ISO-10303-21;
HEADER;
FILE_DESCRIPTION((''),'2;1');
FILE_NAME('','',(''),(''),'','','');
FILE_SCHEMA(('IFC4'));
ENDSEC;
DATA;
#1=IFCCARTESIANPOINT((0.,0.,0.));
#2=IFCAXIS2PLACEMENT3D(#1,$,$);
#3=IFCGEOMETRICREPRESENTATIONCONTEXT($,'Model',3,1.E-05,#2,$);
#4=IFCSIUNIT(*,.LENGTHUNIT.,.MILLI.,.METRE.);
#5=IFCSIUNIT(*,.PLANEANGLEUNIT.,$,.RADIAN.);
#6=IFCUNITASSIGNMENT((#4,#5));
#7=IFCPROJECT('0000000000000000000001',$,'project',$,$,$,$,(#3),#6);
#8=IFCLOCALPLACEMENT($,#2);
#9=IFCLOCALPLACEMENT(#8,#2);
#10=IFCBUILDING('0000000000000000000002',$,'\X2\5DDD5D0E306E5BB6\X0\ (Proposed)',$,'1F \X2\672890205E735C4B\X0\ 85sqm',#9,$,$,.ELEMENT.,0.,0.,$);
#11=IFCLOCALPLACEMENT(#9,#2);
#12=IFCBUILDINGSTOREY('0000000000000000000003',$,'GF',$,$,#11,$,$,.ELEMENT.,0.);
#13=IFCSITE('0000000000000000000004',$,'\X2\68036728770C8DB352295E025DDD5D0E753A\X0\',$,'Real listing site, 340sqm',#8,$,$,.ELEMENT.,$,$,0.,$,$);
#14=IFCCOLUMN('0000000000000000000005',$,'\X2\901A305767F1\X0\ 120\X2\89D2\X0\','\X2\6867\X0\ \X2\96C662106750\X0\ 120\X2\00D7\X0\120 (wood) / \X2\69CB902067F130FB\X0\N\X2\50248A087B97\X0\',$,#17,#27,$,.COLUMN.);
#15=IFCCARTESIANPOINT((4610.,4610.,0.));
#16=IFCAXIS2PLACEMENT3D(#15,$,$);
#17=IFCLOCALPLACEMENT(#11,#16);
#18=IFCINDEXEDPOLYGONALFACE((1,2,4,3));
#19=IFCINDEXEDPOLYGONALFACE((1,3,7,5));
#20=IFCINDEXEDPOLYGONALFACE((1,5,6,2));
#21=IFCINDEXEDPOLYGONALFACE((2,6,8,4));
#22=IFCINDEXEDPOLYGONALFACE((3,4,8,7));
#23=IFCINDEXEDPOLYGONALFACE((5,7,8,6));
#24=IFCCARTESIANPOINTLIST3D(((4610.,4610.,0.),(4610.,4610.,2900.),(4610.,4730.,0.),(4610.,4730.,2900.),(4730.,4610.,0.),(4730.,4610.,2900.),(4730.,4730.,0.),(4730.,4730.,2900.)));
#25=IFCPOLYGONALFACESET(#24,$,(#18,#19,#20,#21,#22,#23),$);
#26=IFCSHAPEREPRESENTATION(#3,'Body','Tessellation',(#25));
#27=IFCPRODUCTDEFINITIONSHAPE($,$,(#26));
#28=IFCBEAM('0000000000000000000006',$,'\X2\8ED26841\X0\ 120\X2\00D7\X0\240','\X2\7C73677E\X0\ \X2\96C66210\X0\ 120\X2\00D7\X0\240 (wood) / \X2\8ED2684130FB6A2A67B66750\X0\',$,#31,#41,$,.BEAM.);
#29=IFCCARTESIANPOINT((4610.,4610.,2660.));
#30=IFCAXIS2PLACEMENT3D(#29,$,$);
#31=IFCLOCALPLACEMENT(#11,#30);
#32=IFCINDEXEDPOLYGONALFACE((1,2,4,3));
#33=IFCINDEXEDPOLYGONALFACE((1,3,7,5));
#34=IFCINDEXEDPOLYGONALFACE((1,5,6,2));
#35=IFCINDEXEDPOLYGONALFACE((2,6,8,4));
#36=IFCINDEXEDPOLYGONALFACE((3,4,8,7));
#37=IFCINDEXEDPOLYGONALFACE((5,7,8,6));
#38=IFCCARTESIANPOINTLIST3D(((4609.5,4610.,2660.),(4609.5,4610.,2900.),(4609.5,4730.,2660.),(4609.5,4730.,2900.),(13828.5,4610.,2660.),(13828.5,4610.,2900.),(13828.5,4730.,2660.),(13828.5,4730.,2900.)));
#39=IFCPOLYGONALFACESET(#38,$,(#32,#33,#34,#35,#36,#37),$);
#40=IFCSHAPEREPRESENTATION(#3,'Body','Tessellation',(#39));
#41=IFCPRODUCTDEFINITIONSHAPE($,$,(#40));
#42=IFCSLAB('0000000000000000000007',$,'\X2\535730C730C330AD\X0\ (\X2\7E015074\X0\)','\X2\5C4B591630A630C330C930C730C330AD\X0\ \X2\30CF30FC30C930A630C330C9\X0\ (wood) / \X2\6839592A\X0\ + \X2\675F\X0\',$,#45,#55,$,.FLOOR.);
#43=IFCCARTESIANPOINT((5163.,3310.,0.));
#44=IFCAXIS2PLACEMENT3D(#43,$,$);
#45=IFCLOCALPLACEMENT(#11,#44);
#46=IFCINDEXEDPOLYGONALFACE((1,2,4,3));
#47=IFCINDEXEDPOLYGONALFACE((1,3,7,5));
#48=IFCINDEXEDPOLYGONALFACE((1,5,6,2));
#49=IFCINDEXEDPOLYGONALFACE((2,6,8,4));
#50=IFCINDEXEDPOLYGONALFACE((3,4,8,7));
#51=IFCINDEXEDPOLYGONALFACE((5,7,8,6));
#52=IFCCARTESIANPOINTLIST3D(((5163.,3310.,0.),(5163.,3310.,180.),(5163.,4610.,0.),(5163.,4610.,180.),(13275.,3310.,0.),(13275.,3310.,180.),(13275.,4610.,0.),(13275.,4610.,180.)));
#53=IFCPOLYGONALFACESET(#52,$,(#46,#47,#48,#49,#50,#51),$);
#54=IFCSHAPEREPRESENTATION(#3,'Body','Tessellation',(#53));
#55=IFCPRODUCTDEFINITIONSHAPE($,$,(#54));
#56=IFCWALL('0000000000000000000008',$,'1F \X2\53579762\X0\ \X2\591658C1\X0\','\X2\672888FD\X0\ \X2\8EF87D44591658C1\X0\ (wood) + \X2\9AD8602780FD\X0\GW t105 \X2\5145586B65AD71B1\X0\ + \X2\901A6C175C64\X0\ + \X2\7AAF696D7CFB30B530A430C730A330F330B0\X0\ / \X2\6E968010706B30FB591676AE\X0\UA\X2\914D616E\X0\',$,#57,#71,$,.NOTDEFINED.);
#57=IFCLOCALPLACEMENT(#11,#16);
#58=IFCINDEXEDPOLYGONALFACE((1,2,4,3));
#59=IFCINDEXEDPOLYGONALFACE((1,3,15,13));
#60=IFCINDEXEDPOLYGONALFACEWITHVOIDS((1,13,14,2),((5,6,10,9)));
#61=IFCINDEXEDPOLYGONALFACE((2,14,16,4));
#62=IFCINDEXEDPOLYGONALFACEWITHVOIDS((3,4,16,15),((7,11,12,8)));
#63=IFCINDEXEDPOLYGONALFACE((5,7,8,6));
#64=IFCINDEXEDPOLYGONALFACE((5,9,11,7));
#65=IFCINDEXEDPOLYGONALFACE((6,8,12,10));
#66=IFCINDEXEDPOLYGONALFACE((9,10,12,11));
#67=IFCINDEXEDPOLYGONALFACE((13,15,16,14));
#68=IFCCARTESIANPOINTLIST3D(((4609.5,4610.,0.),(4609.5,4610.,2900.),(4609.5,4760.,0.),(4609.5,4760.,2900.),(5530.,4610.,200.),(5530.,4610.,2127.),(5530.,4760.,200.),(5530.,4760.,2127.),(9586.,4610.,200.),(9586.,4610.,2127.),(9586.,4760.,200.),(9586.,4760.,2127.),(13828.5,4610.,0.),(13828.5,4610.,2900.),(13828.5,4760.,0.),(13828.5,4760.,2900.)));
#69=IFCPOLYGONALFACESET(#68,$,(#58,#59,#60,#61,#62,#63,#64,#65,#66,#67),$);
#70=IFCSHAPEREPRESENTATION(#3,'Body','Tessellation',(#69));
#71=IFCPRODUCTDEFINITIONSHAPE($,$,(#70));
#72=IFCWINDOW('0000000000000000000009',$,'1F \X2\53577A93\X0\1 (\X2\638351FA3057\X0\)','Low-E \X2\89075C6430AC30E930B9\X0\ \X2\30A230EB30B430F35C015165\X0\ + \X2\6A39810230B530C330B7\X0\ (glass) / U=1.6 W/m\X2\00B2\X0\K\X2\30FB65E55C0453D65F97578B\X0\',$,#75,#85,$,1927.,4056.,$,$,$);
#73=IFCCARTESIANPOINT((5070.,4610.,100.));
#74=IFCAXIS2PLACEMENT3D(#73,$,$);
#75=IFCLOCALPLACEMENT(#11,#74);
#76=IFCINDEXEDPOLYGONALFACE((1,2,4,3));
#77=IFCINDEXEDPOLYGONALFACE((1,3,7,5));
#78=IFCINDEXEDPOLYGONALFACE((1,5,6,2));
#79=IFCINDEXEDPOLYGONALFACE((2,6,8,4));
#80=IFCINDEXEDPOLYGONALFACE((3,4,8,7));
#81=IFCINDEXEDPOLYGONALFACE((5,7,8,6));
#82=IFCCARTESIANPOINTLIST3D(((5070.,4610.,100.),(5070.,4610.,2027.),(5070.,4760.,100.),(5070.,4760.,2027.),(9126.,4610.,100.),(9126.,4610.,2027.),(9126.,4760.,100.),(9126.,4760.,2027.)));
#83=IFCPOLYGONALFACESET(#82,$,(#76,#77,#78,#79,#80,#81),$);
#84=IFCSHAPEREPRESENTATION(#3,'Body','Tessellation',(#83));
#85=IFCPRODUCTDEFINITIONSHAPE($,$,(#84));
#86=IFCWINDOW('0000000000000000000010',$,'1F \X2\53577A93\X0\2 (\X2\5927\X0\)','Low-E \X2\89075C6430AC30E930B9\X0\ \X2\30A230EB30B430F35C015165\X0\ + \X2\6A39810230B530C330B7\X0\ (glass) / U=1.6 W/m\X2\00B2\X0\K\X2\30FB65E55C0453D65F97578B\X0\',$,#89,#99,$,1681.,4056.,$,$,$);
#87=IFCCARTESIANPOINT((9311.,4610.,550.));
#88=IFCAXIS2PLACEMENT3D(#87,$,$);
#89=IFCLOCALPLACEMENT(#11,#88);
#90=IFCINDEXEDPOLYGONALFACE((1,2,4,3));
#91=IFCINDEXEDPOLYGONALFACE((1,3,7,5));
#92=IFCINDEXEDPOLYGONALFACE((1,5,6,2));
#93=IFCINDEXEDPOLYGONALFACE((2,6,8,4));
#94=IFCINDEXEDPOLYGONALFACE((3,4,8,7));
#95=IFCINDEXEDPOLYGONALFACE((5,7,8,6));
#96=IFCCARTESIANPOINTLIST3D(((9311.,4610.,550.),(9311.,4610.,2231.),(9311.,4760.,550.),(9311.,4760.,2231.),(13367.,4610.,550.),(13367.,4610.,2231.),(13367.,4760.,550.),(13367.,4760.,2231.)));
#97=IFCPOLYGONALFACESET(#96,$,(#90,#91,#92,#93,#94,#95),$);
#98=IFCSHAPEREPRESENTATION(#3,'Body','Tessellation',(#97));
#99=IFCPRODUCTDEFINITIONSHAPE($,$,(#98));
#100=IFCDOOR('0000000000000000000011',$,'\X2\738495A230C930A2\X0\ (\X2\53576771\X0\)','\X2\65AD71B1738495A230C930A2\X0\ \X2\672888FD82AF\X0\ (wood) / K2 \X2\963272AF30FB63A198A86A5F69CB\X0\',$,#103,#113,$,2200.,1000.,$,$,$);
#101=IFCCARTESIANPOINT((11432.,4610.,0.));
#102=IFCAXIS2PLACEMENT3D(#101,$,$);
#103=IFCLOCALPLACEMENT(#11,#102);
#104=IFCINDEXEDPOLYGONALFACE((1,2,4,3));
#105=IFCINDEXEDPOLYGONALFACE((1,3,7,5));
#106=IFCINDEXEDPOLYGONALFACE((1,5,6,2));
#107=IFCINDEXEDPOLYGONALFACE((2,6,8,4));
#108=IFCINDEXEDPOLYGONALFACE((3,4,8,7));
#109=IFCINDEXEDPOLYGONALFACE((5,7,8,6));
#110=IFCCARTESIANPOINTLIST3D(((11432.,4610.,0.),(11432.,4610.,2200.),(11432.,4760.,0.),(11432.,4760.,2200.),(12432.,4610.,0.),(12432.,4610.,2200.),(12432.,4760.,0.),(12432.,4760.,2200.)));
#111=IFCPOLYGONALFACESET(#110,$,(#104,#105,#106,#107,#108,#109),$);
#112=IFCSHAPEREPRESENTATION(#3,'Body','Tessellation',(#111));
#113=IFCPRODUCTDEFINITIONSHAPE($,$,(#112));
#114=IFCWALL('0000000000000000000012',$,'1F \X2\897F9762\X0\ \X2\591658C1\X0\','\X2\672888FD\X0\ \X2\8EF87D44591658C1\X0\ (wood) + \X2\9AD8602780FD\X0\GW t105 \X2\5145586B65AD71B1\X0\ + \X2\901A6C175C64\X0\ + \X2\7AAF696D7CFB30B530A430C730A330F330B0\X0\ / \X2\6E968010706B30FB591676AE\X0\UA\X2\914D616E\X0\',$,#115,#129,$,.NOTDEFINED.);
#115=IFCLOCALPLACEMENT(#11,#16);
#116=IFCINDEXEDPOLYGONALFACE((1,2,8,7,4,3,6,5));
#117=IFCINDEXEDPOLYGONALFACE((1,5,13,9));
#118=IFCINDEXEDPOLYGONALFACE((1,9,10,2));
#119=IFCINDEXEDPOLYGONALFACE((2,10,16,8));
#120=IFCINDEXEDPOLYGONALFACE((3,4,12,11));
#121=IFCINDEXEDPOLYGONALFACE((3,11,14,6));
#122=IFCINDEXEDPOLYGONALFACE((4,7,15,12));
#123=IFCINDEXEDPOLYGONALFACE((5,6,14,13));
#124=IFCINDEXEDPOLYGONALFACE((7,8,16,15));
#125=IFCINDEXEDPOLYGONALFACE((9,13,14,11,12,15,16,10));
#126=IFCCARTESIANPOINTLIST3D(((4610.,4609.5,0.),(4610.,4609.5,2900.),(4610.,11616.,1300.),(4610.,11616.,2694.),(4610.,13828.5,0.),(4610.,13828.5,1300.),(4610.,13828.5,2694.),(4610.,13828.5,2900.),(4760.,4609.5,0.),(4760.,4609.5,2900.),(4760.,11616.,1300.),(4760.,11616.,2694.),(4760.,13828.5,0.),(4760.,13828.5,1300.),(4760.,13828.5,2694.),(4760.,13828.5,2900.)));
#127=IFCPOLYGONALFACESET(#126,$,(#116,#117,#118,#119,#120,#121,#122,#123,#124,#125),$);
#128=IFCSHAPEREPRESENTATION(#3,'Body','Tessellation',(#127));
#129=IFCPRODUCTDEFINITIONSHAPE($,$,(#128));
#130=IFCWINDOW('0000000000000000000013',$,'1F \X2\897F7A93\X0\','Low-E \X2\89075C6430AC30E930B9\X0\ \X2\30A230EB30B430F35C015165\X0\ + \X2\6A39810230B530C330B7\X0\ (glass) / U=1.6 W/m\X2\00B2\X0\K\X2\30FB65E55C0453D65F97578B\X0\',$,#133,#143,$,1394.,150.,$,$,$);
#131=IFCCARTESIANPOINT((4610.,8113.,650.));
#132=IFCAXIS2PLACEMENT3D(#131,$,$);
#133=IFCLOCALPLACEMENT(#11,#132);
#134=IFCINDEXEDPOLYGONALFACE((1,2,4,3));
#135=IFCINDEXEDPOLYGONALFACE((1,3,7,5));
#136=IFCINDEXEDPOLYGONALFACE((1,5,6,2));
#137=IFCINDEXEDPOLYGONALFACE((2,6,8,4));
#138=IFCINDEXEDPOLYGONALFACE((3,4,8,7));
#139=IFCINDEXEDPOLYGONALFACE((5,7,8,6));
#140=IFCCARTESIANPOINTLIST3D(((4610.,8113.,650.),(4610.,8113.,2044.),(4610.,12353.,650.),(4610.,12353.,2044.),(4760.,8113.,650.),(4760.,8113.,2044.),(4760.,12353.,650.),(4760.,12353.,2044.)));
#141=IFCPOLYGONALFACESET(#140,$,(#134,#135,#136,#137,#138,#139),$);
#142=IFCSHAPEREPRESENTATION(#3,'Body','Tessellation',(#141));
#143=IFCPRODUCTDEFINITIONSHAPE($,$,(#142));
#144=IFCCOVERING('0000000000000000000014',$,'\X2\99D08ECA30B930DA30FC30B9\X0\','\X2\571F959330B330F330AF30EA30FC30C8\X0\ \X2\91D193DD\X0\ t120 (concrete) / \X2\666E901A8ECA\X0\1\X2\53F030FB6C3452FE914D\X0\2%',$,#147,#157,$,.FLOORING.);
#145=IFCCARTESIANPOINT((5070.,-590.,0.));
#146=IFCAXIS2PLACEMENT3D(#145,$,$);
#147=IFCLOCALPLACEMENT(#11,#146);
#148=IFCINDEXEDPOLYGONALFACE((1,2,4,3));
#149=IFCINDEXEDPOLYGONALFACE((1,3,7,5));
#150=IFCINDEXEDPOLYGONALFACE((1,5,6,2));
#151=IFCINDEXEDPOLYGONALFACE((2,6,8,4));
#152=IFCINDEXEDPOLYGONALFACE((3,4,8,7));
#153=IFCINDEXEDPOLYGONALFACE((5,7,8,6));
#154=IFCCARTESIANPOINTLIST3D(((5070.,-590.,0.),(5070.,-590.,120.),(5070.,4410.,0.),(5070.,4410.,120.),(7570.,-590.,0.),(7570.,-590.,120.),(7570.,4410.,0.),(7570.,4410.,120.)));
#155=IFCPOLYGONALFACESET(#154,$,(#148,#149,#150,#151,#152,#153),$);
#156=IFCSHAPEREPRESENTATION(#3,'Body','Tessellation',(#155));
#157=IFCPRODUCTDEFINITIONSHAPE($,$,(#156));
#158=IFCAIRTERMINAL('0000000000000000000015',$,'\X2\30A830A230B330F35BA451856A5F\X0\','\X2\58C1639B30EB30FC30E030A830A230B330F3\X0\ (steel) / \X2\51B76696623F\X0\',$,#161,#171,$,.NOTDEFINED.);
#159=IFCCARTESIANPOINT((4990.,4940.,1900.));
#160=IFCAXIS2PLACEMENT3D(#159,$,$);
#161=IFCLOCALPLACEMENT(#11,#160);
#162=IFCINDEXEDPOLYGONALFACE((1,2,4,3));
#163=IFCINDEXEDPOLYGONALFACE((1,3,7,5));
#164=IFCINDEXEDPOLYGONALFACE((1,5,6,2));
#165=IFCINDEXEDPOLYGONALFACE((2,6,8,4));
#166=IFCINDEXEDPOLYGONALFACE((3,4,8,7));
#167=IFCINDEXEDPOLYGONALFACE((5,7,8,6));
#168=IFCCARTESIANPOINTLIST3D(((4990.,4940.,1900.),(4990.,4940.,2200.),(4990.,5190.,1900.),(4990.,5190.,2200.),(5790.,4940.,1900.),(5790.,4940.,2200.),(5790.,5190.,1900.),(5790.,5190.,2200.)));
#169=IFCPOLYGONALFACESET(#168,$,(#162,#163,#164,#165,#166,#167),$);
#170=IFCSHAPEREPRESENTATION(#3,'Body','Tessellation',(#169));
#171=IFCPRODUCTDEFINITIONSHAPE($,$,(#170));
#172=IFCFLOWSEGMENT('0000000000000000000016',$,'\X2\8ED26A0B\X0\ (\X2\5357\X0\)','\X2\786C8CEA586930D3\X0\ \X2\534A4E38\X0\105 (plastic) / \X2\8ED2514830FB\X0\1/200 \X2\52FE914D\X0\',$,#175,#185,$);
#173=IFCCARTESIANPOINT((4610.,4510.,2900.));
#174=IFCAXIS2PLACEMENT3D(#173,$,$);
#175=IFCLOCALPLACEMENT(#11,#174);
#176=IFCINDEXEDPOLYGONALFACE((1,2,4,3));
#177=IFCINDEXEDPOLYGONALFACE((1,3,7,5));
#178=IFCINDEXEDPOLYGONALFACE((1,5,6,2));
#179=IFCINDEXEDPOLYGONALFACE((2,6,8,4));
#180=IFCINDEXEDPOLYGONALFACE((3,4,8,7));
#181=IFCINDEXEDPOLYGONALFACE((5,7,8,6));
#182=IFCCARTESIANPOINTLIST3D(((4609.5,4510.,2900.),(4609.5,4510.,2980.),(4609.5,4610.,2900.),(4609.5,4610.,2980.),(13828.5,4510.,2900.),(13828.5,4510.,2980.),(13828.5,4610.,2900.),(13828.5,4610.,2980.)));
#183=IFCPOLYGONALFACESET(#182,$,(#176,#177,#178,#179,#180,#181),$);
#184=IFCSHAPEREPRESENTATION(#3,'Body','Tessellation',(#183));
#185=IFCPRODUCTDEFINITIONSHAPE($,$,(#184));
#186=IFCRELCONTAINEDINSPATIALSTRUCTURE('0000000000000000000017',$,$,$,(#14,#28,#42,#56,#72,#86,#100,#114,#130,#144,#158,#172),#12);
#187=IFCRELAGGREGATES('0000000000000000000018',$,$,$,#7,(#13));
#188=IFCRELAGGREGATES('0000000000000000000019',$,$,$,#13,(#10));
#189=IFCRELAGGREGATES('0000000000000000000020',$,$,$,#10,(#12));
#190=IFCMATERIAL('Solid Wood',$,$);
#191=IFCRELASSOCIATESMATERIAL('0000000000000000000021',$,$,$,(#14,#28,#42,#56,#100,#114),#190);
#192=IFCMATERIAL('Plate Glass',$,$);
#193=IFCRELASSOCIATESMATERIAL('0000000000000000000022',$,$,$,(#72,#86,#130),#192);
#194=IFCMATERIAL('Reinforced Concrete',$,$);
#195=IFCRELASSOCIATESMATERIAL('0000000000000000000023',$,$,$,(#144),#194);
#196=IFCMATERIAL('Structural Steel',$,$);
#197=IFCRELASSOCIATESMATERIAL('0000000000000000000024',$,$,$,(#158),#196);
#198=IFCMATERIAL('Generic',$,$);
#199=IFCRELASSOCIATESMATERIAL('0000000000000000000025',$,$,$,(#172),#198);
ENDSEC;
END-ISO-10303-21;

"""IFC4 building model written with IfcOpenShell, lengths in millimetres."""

from ifc_helpers import new_model, si_unit, frame, frame_2d, origin, place, context, project, spatial, rectangle, extrude, material, element, fill, save


model = new_model("IFC4")

# Units and contexts
model_context = context("Model", 3, precision=1e-05, world=origin())
ifc_project = project(units=[si_unit("LENGTHUNIT", "METRE", prefix="MILLI"), si_unit("PLANEANGLEUNIT", "RADIAN")], contexts=[model_context])

# Site, building, storey
site_placement = place(None, origin())
site = spatial("IfcSite", under=ifc_project, at=site_placement, Name="栃木県足利市川崎町", ObjectType="Real listing site, 340sqm", CompositionType="ELEMENT", RefElevation=0.0)
building_placement = place(site_placement, origin())
building = spatial("IfcBuilding", under=site, at=building_placement, Name="川崎の家 (Proposed)", ObjectType="1F 木造平屋 85sqm", CompositionType="ELEMENT", ElevationOfRefHeight=0.0, ElevationOfTerrain=0.0)
storey_placement = place(building_placement, origin())
storey = spatial("IfcBuildingStorey", under=building, at=storey_placement, Name="GF", CompositionType="ELEMENT", Elevation=0.0)

# Column
ifc_material_1 = material(Name="Solid Wood")
column_1_placement = place(storey_placement, frame((4610.0, 4610.0, 0.0)))
element("IfcColumn", 1, at=column_1_placement, inside=storey, material=ifc_material_1, Name="通し柱 120角", Description="桧 集成材 120×120 (wood) / 構造柱・N値計算", PredefinedType="COLUMN", context=model_context, shape_type="SweptSolid", body=[
    extrude(rectangle(XDim=120.0, YDim=120.0, at=frame_2d((60.0, 60.0))), frame((4610.0, 4610.0, 0.0)), (0.0, 0.0, 1.0), 2900.0),
])

# Beam
beam_1_placement = place(storey_placement, frame((4610.0, 4610.0, 2660.0)))
element("IfcBeam", 2, at=beam_1_placement, inside=storey, material=ifc_material_1, Name="軒桁 120×240", Description="米松 集成 120×240 (wood) / 軒桁・横架材", PredefinedType="BEAM", context=model_context, shape_type="SweptSolid", body=[
    extrude(rectangle(XDim=9219.0, YDim=120.0, at=frame_2d((4609.0, 60.0))), frame((4610.0, 4610.0, 2660.0)), (0.0, 0.0, 1.0), 240.0),
])

# Slab
ifc_material_2 = material(Name="Reinforced Concrete")
slab_1_placement = place(storey_placement, frame((5163.0, 3310.0, 0.0)))
element("IfcSlab", 3, at=slab_1_placement, inside=storey, material=ifc_material_1, Name="南デッキ (縁側)", Description="屋外ウッドデッキ ハードウッド (wood) / 根太 + 束", PredefinedType="FLOOR", context=model_context, shape_type="SweptSolid", body=[
    extrude(rectangle(XDim=8112.0, YDim=1300.0, at=frame_2d((4056.0, 650.0))), frame((5163.0, 3310.0, 0.0)), (0.0, 0.0, 1.0), 180.0),
])

# Wall, openings, windows, door
wall_1_placement = place(storey_placement, frame((4610.0, 4610.0, 0.0)))
wall_1 = element("IfcWall", 4, at=wall_1_placement, inside=storey, material=ifc_material_1, Name="1F 南面 外壁", Description="木製 軸組外壁 (wood) + 高性能GW t105 充填断熱 + 通気層 + 窯業系サイディング / 準耐火・外皮UA配慮", PredefinedType="NOTDEFINED", context=model_context, shape_type="SweptSolid", body=[
    extrude(rectangle(XDim=9219.0, YDim=150.0, at=frame_2d((4609.0, 75.0))), frame((4610.0, 4610.0, 0.0)), (0.0, 0.0, 1.0), 2900.0),
])
opening_1_placement = place(storey_placement, frame((5070.0, 4610.0, 100.0)))
opening_1 = element("IfcOpeningElement", 5, at=opening_1_placement, cuts=wall_1, PredefinedType="NOTDEFINED", context=model_context, shape_type="SweptSolid", body=[
    extrude(rectangle(XDim=4056.0, YDim=150.0, at=frame_2d((2028.0, 75.0))), frame((5070.0, 4610.0, 100.0)), (0.0, 0.0, 1.0), 1927.0),
])
opening_2_placement = place(storey_placement, frame((9311.0, 4610.0, 550.0)))
opening_2 = element("IfcOpeningElement", 6, at=opening_2_placement, cuts=wall_1, PredefinedType="NOTDEFINED", context=model_context, shape_type="SweptSolid", body=[
    extrude(rectangle(XDim=4056.0, YDim=150.0, at=frame_2d((2028.0, 75.0))), frame((9311.0, 4610.0, 550.0)), (0.0, 0.0, 1.0), 1681.0),
])
opening_3_placement = place(storey_placement, frame((11432.0, 4610.0, 0.0)))
opening_3 = element("IfcOpeningElement", 7, at=opening_3_placement, cuts=wall_1, PredefinedType="NOTDEFINED", context=model_context, shape_type="SweptSolid", body=[
    extrude(rectangle(XDim=1000.0, YDim=150.0, at=frame_2d((500.0, 75.0))), frame((11432.0, 4610.0, 0.0)), (0.0, 0.0, 1.0), 2200.0),
])
ifc_material_3 = material(Name="Plate Glass")
window_1_placement = place(storey_placement, frame((5070.0, 4610.0, 100.0)))
window_1 = element("IfcWindow", 8, at=window_1_placement, inside=storey, material=ifc_material_3, Name="1F 南窓1 (掃出し)", Description="Low-E 複層ガラス アルゴン封入 + 樹脂サッシ (glass) / U=1.6 W/m²K・日射取得型", OverallHeight=1927.0, OverallWidth=4056.0, context=model_context, shape_type="SweptSolid", body=[
    extrude(rectangle(XDim=4056.0, YDim=150.0, at=frame_2d((2028.0, 75.0))), frame((5070.0, 4610.0, 100.0)), (0.0, 0.0, 1.0), 1927.0),
])
fill(opening_1, window_1)
window_2_placement = place(storey_placement, frame((9311.0, 4610.0, 550.0)))
window_2 = element("IfcWindow", 9, at=window_2_placement, inside=storey, material=ifc_material_3, Name="1F 南窓2 (大)", Description="Low-E 複層ガラス アルゴン封入 + 樹脂サッシ (glass) / U=1.6 W/m²K・日射取得型", OverallHeight=1681.0, OverallWidth=4056.0, context=model_context, shape_type="SweptSolid", body=[
    extrude(rectangle(XDim=4056.0, YDim=150.0, at=frame_2d((2028.0, 75.0))), frame((9311.0, 4610.0, 550.0)), (0.0, 0.0, 1.0), 1681.0),
])
fill(opening_2, window_2)
door_placement = place(storey_placement, frame((11432.0, 4610.0, 0.0)))
door = element("IfcDoor", 10, at=door_placement, inside=storey, material=ifc_material_1, Name="玄関ドア (南東)", Description="断熱玄関ドア 木製芯 (wood) / K2 防犯・採風機構", OverallHeight=2200.0, OverallWidth=1000.0, context=model_context, shape_type="SweptSolid", body=[
    extrude(rectangle(XDim=1000.0, YDim=150.0, at=frame_2d((500.0, 75.0))), frame((11432.0, 4610.0, 0.0)), (0.0, 0.0, 1.0), 2200.0),
])
fill(opening_3, door)

# Wall, opening, window
wall_2_placement = place(storey_placement, frame((4610.0, 4610.0, 0.0)))
wall_2 = element("IfcWall", 11, at=wall_2_placement, inside=storey, material=ifc_material_1, Name="1F 西面 外壁", Description="木製 軸組外壁 (wood) + 高性能GW t105 充填断熱 + 通気層 + 窯業系サイディング / 準耐火・外皮UA配慮", PredefinedType="NOTDEFINED", context=model_context, shape_type="SweptSolid", body=[
    extrude(rectangle(XDim=150.0, YDim=9219.0, at=frame_2d((75.0, 4609.0))), frame((4610.0, 4610.0, 0.0)), (0.0, 0.0, 1.0), 2900.0),
])
opening_4_placement = place(storey_placement, frame((4610.0, 8113.0, 650.0)))
opening_4 = element("IfcOpeningElement", 12, at=opening_4_placement, cuts=wall_2, PredefinedType="NOTDEFINED", context=model_context, shape_type="SweptSolid", body=[
    extrude(rectangle(XDim=150.0, YDim=4240.0, at=frame_2d((75.0, 2120.0))), frame((4610.0, 8113.0, 650.0)), (0.0, 0.0, 1.0), 1394.0),
])
window_3_placement = place(storey_placement, frame((4610.0, 8113.0, 650.0)))
window_3 = element("IfcWindow", 13, at=window_3_placement, inside=storey, material=ifc_material_3, Name="1F 西窓", Description="Low-E 複層ガラス アルゴン封入 + 樹脂サッシ (glass) / U=1.6 W/m²K・日射取得型", OverallHeight=1394.0, OverallWidth=150.0, context=model_context, shape_type="SweptSolid", body=[
    extrude(rectangle(XDim=150.0, YDim=4240.0, at=frame_2d((75.0, 2120.0))), frame((4610.0, 8113.0, 650.0)), (0.0, 0.0, 1.0), 1394.0),
])
fill(opening_4, window_3)

# Shared definitions
ifc_material_4 = material(Name="Structural Steel")

# Covering
ifc_material_5 = material(Name="Generic")
covering_1_placement = place(storey_placement, frame((5070.0, -590.0, 0.0)))
element("IfcCovering", 14, at=covering_1_placement, inside=storey, material=ifc_material_2, Name="駐車スペース", Description="土間コンクリート 金鏝 t120 (concrete) / 普通車1台・水勾配2%", PredefinedType="FLOORING", context=model_context, shape_type="SweptSolid", body=[
    extrude(rectangle(XDim=2500.0, YDim=5000.0, at=frame_2d((1250.0, 2500.0))), frame((5070.0, -590.0, 0.0)), (0.0, 0.0, 1.0), 120.0),
])

# Air terminal
air_terminal_placement = place(storey_placement, frame((4990.0, 4940.0, 1900.0)))
element("IfcAirTerminal", 15, at=air_terminal_placement, inside=storey, material=ifc_material_4, Name="エアコン室内機", Description="壁掛ルームエアコン (steel) / 冷暖房", PredefinedType="NOTDEFINED", context=model_context, shape_type="SweptSolid", body=[
    extrude(rectangle(XDim=800.0, YDim=250.0, at=frame_2d((400.0, 125.0))), frame((4990.0, 4940.0, 1900.0)), (0.0, 0.0, 1.0), 300.0),
])

# Flow segment
flow_segment_1_placement = place(storey_placement, frame((4610.0, 4510.0, 2900.0)))
element("IfcFlowSegment", 16, at=flow_segment_1_placement, inside=storey, material=ifc_material_5, Name="軒樋 (南)", Description="硬質塩ビ 半丸105 (plastic) / 軒先・1/200 勾配", context=model_context, shape_type="SweptSolid", body=[
    extrude(rectangle(XDim=9219.0, YDim=100.0, at=frame_2d((4609.0, 50.0))), frame((4610.0, 4510.0, 2900.0)), (0.0, 0.0, 1.0), 80.0),
])

save(model, "model.ifc")
